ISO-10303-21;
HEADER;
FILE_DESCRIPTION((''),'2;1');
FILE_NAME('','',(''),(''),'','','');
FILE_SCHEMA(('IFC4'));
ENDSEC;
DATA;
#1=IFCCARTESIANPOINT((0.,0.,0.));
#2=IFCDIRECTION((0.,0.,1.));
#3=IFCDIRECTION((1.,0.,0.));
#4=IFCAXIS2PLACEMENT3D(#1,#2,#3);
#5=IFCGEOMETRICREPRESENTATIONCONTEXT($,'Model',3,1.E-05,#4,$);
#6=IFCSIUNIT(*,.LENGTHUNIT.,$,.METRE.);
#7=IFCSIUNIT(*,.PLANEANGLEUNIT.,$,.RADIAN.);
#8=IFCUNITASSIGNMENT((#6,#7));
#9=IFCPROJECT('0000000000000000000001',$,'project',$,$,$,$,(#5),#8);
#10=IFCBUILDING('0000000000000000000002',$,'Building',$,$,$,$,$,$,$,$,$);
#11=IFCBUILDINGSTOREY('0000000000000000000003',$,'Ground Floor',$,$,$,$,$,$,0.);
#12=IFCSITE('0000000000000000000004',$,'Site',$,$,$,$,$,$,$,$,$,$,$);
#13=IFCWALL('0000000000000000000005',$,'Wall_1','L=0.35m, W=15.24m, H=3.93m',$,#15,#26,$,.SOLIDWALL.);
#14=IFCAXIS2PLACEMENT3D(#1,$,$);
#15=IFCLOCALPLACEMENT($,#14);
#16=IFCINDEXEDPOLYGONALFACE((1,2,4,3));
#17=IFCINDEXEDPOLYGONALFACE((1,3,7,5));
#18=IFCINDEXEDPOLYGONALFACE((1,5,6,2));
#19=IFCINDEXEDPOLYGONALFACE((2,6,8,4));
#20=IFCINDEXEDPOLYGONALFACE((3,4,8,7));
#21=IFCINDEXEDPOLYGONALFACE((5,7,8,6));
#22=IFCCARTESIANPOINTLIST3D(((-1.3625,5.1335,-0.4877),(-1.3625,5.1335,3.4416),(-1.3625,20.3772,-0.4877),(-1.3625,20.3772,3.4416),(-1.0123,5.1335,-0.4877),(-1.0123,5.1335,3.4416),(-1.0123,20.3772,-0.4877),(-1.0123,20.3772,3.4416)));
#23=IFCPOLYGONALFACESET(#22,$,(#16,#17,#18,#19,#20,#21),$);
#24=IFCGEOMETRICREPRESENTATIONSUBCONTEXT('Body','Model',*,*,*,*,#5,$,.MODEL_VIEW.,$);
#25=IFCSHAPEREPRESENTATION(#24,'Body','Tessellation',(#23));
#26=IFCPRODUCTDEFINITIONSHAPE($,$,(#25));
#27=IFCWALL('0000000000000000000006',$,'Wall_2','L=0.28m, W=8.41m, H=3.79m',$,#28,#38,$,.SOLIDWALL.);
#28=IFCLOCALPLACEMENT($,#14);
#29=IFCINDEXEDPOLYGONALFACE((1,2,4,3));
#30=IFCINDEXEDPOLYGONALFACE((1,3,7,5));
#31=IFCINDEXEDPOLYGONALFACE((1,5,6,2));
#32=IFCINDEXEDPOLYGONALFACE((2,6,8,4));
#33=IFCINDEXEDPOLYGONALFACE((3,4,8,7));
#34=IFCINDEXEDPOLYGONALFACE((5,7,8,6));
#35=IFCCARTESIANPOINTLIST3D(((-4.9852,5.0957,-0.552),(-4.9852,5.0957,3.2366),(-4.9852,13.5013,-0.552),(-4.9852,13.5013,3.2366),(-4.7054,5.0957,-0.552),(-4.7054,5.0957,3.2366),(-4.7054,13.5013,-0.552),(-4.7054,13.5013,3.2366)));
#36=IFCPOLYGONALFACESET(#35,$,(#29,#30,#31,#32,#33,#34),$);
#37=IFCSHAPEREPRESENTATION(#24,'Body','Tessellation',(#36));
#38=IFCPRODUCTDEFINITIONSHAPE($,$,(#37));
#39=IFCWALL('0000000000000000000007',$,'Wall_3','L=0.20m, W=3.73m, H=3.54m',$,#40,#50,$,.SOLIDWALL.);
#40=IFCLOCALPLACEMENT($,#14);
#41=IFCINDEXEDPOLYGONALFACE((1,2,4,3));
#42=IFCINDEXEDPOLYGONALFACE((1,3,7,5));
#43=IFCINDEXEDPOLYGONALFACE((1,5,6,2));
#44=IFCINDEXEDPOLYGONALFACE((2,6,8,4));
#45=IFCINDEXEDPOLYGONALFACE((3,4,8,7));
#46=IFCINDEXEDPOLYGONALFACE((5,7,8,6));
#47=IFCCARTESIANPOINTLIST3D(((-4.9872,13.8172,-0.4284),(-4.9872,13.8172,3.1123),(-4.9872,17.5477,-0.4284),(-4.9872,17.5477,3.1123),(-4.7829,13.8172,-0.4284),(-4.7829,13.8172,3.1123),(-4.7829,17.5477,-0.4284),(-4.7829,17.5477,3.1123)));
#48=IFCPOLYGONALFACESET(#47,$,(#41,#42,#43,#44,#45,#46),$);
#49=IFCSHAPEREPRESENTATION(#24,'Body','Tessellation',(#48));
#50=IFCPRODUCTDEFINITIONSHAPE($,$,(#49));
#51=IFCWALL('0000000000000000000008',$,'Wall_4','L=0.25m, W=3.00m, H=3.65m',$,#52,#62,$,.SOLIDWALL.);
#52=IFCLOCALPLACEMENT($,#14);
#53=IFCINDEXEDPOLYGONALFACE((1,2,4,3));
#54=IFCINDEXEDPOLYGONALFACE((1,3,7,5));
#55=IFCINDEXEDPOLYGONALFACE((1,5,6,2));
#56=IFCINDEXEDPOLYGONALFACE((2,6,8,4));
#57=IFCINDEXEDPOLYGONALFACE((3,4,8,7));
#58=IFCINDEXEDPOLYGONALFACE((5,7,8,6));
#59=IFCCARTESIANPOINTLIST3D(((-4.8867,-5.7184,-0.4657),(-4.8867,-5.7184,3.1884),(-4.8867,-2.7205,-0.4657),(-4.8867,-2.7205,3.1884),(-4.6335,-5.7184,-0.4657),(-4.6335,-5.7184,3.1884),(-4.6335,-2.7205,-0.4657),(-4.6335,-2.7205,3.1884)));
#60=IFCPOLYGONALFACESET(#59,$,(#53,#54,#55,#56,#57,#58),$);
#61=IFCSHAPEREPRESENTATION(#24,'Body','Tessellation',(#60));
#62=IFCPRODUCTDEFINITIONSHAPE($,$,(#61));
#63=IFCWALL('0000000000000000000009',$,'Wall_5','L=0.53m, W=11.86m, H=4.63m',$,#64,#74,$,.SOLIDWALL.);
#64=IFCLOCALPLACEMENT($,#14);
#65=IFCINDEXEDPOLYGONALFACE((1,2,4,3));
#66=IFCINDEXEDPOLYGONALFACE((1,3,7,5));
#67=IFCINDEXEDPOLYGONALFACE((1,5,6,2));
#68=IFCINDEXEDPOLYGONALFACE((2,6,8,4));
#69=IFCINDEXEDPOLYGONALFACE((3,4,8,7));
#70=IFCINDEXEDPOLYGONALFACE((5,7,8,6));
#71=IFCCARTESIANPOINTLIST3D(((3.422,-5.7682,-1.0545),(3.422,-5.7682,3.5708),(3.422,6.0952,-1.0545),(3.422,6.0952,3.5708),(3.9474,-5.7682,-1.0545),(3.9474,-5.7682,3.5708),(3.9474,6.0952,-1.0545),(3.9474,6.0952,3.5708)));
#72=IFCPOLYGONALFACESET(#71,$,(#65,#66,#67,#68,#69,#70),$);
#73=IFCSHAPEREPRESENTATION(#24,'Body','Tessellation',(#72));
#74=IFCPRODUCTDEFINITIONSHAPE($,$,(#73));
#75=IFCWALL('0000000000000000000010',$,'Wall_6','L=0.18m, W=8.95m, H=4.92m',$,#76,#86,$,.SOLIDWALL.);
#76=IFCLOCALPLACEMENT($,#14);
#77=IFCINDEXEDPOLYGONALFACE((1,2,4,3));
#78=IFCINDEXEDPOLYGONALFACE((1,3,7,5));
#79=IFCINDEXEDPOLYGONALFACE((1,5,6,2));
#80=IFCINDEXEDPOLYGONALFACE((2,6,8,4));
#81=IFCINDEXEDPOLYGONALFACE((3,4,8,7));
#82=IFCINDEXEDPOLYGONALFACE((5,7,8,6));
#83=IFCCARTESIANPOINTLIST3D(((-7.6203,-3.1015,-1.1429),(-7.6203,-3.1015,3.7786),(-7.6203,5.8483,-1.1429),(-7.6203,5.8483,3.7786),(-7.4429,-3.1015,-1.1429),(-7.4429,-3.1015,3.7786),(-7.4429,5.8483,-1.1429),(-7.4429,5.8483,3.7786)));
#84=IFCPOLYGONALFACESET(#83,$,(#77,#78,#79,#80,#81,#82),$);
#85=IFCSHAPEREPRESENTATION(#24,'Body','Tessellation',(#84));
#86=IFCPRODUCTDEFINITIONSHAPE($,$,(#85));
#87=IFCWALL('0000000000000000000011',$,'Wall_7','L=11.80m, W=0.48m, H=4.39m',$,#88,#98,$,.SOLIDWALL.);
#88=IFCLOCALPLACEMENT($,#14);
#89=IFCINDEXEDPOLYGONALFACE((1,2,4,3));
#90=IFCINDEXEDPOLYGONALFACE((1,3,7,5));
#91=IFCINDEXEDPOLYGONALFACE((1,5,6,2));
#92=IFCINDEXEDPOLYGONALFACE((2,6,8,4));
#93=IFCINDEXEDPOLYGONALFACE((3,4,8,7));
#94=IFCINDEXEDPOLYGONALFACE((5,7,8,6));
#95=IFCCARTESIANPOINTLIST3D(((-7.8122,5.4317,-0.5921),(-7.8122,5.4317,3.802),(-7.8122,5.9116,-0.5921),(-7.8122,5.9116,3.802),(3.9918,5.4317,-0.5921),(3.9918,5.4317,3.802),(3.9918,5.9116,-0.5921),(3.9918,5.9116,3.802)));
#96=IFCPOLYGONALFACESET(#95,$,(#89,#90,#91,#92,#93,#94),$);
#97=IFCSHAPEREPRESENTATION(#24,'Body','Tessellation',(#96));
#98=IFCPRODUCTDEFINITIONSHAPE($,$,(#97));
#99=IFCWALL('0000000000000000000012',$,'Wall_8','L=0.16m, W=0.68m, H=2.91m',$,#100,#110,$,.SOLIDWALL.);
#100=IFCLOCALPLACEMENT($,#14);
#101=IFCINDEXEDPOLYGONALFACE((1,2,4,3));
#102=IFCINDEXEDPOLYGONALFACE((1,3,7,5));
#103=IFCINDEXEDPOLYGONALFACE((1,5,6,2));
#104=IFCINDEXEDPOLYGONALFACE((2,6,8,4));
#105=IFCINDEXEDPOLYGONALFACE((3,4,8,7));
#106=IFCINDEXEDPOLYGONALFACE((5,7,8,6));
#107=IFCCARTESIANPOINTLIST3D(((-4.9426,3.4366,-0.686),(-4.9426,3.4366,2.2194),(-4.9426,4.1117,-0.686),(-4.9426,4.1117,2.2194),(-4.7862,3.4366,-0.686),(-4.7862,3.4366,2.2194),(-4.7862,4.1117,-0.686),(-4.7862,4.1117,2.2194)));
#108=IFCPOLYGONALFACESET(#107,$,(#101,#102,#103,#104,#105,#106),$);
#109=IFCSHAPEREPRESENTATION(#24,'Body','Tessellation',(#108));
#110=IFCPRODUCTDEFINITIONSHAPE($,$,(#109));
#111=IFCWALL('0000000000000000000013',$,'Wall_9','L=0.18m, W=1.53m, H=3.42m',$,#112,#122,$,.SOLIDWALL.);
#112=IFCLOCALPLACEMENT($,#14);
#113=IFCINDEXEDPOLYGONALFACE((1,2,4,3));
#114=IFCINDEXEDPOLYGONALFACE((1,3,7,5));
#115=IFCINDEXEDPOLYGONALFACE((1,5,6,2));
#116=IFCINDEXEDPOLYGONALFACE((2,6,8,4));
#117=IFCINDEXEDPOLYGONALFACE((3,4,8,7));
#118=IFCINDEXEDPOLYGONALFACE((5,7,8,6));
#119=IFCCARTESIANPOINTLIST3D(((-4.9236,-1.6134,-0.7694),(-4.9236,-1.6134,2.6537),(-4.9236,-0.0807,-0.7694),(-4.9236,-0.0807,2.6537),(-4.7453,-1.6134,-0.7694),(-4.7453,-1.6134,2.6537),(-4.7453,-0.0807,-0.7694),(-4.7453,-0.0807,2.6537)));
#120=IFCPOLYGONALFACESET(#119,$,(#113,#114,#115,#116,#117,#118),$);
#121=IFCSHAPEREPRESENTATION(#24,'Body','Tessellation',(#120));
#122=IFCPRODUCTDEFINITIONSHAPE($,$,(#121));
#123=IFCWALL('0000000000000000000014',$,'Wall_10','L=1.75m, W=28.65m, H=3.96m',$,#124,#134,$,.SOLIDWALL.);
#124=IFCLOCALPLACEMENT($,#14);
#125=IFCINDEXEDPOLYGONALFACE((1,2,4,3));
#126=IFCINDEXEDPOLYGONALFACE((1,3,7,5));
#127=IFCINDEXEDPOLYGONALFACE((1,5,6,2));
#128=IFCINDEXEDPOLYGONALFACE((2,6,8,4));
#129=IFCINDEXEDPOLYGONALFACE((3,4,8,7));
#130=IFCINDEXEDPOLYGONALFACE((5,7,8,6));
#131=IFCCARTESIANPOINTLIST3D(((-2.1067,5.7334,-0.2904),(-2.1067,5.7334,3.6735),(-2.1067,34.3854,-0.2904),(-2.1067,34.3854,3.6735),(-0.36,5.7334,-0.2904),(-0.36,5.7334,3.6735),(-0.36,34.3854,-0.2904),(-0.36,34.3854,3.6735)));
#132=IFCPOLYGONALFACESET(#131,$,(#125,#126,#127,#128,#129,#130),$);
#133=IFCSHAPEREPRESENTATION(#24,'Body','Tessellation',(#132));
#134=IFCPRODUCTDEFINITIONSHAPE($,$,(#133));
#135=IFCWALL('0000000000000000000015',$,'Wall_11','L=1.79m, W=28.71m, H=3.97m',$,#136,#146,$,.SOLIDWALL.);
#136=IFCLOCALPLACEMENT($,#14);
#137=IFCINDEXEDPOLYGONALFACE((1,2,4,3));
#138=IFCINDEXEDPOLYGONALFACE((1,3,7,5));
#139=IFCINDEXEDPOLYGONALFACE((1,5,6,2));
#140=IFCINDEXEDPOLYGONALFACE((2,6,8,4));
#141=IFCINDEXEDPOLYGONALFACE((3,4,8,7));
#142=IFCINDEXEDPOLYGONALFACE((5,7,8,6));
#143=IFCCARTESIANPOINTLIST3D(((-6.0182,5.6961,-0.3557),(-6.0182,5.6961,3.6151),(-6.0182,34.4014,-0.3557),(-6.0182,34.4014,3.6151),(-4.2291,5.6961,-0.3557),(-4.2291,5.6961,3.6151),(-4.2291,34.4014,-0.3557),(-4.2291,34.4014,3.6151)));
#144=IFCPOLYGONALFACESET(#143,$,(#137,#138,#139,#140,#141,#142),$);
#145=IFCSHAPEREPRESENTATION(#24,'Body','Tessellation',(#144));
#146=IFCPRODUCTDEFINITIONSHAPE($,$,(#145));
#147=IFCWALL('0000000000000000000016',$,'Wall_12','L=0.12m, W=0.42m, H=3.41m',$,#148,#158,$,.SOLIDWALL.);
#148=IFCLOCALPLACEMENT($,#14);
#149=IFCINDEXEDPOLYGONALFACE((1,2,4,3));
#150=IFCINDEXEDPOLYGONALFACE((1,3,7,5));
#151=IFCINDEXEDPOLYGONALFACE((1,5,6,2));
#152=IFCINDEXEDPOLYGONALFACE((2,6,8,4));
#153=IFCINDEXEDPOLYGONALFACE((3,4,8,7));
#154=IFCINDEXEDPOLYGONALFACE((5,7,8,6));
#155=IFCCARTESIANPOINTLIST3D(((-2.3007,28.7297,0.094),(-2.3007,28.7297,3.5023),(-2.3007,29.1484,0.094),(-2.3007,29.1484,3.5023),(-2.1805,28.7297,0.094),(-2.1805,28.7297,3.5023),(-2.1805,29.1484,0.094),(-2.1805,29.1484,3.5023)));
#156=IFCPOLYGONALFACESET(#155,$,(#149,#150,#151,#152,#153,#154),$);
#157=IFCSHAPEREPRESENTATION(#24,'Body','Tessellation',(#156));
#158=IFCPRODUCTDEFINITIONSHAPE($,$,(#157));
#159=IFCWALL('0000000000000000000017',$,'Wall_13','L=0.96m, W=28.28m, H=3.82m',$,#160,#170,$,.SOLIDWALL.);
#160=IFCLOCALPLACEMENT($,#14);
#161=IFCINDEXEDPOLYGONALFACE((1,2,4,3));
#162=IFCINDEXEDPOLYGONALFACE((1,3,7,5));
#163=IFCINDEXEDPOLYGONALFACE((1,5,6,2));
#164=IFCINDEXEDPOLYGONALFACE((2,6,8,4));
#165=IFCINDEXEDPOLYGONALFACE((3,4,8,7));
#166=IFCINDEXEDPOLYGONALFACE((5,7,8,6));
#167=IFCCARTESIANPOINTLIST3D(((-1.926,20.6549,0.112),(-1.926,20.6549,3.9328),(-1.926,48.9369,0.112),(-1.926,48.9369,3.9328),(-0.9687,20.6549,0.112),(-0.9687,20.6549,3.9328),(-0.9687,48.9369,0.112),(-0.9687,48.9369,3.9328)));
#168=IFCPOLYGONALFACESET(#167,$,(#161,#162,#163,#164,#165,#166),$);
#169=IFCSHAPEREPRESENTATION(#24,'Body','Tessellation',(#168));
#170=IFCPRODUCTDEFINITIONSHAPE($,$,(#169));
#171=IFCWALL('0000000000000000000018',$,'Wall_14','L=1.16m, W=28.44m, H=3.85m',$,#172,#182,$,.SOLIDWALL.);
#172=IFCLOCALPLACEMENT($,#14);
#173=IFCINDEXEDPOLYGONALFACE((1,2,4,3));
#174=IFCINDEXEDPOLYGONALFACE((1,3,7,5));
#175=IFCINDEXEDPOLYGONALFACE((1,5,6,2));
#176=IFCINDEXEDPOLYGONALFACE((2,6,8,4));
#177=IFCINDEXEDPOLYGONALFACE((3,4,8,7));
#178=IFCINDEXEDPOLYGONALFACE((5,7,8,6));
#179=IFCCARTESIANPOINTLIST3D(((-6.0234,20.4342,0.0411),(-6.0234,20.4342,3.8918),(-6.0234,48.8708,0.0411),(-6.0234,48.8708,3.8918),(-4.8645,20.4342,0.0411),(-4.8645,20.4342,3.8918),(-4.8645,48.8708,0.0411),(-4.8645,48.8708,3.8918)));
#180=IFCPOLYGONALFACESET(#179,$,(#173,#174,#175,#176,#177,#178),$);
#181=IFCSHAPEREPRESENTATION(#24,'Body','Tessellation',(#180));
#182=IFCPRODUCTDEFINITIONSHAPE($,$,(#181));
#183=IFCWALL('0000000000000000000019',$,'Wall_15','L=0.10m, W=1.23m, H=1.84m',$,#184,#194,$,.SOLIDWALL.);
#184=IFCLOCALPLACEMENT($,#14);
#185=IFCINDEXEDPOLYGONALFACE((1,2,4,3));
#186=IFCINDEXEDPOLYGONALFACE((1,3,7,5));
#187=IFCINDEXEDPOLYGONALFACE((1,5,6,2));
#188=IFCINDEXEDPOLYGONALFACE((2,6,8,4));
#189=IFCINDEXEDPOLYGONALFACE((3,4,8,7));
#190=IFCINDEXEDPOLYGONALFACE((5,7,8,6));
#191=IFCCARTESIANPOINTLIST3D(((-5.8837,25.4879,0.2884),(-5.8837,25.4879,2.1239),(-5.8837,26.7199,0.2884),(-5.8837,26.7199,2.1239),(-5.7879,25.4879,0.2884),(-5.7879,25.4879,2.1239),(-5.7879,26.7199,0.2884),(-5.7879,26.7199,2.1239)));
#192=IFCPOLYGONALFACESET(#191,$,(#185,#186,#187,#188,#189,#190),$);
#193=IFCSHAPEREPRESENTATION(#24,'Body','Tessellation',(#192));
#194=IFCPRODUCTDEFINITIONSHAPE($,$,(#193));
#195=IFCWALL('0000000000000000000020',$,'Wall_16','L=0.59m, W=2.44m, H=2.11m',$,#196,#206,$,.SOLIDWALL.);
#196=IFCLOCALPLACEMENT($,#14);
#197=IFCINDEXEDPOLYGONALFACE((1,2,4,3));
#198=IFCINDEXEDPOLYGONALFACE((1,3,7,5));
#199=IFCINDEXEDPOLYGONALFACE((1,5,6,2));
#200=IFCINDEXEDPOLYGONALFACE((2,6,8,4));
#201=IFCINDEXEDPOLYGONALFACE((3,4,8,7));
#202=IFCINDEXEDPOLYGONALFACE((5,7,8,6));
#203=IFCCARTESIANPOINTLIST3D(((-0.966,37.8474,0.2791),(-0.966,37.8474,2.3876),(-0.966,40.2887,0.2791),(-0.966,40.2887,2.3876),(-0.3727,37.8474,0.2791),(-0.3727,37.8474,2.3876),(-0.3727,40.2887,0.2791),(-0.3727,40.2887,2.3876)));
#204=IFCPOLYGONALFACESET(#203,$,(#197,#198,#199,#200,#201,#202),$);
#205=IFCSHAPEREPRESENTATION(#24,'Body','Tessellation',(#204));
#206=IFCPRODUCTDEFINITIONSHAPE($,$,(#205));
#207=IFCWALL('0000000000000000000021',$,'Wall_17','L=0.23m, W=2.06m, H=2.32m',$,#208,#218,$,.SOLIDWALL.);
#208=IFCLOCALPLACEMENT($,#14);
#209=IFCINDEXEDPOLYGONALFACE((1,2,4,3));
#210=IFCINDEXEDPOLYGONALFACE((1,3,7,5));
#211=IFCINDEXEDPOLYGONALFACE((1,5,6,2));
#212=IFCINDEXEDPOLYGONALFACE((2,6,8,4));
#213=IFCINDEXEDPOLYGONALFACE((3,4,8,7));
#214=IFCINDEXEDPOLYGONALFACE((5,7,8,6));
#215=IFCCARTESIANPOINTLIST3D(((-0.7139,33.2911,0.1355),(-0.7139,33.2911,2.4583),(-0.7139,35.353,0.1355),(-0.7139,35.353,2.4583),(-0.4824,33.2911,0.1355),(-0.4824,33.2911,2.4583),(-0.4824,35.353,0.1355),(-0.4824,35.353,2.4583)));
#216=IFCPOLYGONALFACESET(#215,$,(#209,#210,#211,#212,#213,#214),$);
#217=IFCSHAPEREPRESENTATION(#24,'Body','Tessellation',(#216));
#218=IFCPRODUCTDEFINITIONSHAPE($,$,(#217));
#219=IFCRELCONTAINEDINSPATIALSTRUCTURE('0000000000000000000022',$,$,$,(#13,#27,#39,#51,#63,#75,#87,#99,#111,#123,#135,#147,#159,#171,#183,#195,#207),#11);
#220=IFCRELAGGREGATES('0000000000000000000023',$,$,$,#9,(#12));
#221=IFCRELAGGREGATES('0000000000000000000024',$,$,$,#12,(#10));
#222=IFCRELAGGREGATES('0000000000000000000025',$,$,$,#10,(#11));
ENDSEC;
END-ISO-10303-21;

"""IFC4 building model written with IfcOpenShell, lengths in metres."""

from ifc_helpers import new_model, si_unit, frame, origin_with_axes, origin_2d, context, subcontext, project, spatial, rectangle, extrude, element, save


model = new_model("IFC4")

# Units and contexts
model_context = context("Model", 3, precision=1e-05, world=origin_with_axes())
body_context = subcontext(model_context, "Body", "Model", "MODEL_VIEW")
ifc_project = project(units=[si_unit("LENGTHUNIT", "METRE"), si_unit("PLANEANGLEUNIT", "RADIAN")], contexts=[model_context])

# Site, building, storey
site = spatial("IfcSite", under=ifc_project, Name="Site")
building = spatial("IfcBuilding", under=site, Name="Building")
storey = spatial("IfcBuildingStorey", under=building, Name="Ground Floor", Elevation=0.0)

# Walls
element("IfcWall", 1, inside=storey, Name="Wall_1", Description="L=0.35m, W=15.24m, H=3.93m", PredefinedType="SOLIDWALL", context=body_context, shape_type="SweptSolid", body=[
    extrude(rectangle(XDim=0.3502, YDim=15.2437, at=origin_2d()), frame((-1.1874, 12.7554, -0.4877), z_axis=(0.0, 0.0, 1.0), x_axis=(1.0, 0.0, 0.0)), (0.0, 0.0, 1.0), 3.9293),
])
element("IfcWall", 2, inside=storey, Name="Wall_2", Description="L=0.28m, W=8.41m, H=3.79m", PredefinedType="SOLIDWALL", context=body_context, shape_type="SweptSolid", body=[
    extrude(rectangle(XDim=0.2798, YDim=8.4056, at=origin_2d()), frame((-4.8453, 9.2985, -0.552), z_axis=(0.0, 0.0, 1.0), x_axis=(1.0, 0.0, 0.0)), (0.0, 0.0, 1.0), 3.7887),
])
element("IfcWall", 3, inside=storey, Name="Wall_3", Description="L=0.20m, W=3.73m, H=3.54m", PredefinedType="SOLIDWALL", context=body_context, shape_type="SweptSolid", body=[
    extrude(rectangle(XDim=0.2044, YDim=3.7305, at=origin_2d()), frame((-4.885, 15.6825, -0.4284), z_axis=(0.0, 0.0, 1.0), x_axis=(1.0, 0.0, 0.0)), (0.0, 0.0, 1.0), 3.5408),
])
element("IfcWall", 4, inside=storey, Name="Wall_4", Description="L=0.25m, W=3.00m, H=3.65m", PredefinedType="SOLIDWALL", context=body_context, shape_type="SweptSolid", body=[
    extrude(rectangle(XDim=0.2532, YDim=2.9979, at=origin_2d()), frame((-4.7601, -4.2195, -0.4657), z_axis=(0.0, 0.0, 1.0), x_axis=(1.0, 0.0, 0.0)), (0.0, 0.0, 1.0), 3.6541),
])
element("IfcWall", 5, inside=storey, Name="Wall_5", Description="L=0.53m, W=11.86m, H=4.63m", PredefinedType="SOLIDWALL", context=body_context, shape_type="SweptSolid", body=[
    extrude(rectangle(XDim=0.5253, YDim=11.8635, at=origin_2d()), frame((3.6847, 0.1635, -1.0545), z_axis=(0.0, 0.0, 1.0), x_axis=(1.0, 0.0, 0.0)), (0.0, 0.0, 1.0), 4.6253),
])
element("IfcWall", 6, inside=storey, Name="Wall_6", Description="L=0.18m, W=8.95m, H=4.92m", PredefinedType="SOLIDWALL", context=body_context, shape_type="SweptSolid", body=[
    extrude(rectangle(XDim=0.1774, YDim=8.9498, at=origin_2d()), frame((-7.5316, 1.3734, -1.1429), z_axis=(0.0, 0.0, 1.0), x_axis=(1.0, 0.0, 0.0)), (0.0, 0.0, 1.0), 4.9215),
])
element("IfcWall", 7, inside=storey, Name="Wall_7", Description="L=11.80m, W=0.48m, H=4.39m", PredefinedType="SOLIDWALL", context=body_context, shape_type="SweptSolid", body=[
    extrude(rectangle(XDim=11.804, YDim=0.4799, at=origin_2d()), frame((-1.9102, 5.6717, -0.5921), z_axis=(0.0, 0.0, 1.0), x_axis=(1.0, 0.0, 0.0)), (0.0, 0.0, 1.0), 4.3941),
])
element("IfcWall", 8, inside=storey, Name="Wall_8", Description="L=0.16m, W=0.68m, H=2.91m", PredefinedType="SOLIDWALL", context=body_context, shape_type="SweptSolid", body=[
    extrude(rectangle(XDim=0.1564, YDim=0.6751, at=origin_2d()), frame((-4.8644, 3.7741, -0.686), z_axis=(0.0, 0.0, 1.0), x_axis=(1.0, 0.0, 0.0)), (0.0, 0.0, 1.0), 2.9054),
])
element("IfcWall", 9, inside=storey, Name="Wall_9", Description="L=0.18m, W=1.53m, H=3.42m", PredefinedType="SOLIDWALL", context=body_context, shape_type="SweptSolid", body=[
    extrude(rectangle(XDim=0.1784, YDim=1.5328, at=origin_2d()), frame((-4.8344, -0.8471, -0.7694), z_axis=(0.0, 0.0, 1.0), x_axis=(1.0, 0.0, 0.0)), (0.0, 0.0, 1.0), 3.4231),
])
element("IfcWall", 10, inside=storey, Name="Wall_10", Description="L=1.75m, W=28.65m, H=3.96m", PredefinedType="SOLIDWALL", context=body_context, shape_type="SweptSolid", body=[
    extrude(rectangle(XDim=1.7468, YDim=28.652, at=origin_2d()), frame((-1.2334, 20.0594, -0.2904), z_axis=(0.0, 0.0, 1.0), x_axis=(1.0, 0.0, 0.0)), (0.0, 0.0, 1.0), 3.9639),
])
element("IfcWall", 11, inside=storey, Name="Wall_11", Description="L=1.79m, W=28.71m, H=3.97m", PredefinedType="SOLIDWALL", context=body_context, shape_type="SweptSolid", body=[
    extrude(rectangle(XDim=1.7891, YDim=28.7054, at=origin_2d()), frame((-5.1237, 20.0488, -0.3557), z_axis=(0.0, 0.0, 1.0), x_axis=(1.0, 0.0, 0.0)), (0.0, 0.0, 1.0), 3.9707),
])
element("IfcWall", 12, inside=storey, Name="Wall_12", Description="L=0.12m, W=0.42m, H=3.41m", PredefinedType="SOLIDWALL", context=body_context, shape_type="SweptSolid", body=[
    extrude(rectangle(XDim=0.1202, YDim=0.4187, at=origin_2d()), frame((-2.2406, 28.939, 0.094), z_axis=(0.0, 0.0, 1.0), x_axis=(1.0, 0.0, 0.0)), (0.0, 0.0, 1.0), 3.4083),
])
element("IfcWall", 13, inside=storey, Name="Wall_13", Description="L=0.96m, W=28.28m, H=3.82m", PredefinedType="SOLIDWALL", context=body_context, shape_type="SweptSolid", body=[
    extrude(rectangle(XDim=0.9572, YDim=28.282, at=origin_2d()), frame((-1.4474, 34.7959, 0.112), z_axis=(0.0, 0.0, 1.0), x_axis=(1.0, 0.0, 0.0)), (0.0, 0.0, 1.0), 3.8208),
])
element("IfcWall", 14, inside=storey, Name="Wall_14", Description="L=1.16m, W=28.44m, H=3.85m", PredefinedType="SOLIDWALL", context=body_context, shape_type="SweptSolid", body=[
    extrude(rectangle(XDim=1.1588, YDim=28.4366, at=origin_2d()), frame((-5.444, 34.6525, 0.0411), z_axis=(0.0, 0.0, 1.0), x_axis=(1.0, 0.0, 0.0)), (0.0, 0.0, 1.0), 3.8507),
])
element("IfcWall", 15, inside=storey, Name="Wall_15", Description="L=0.10m, W=1.23m, H=1.84m", PredefinedType="SOLIDWALL", context=body_context, shape_type="SweptSolid", body=[
    extrude(rectangle(XDim=0.0958, YDim=1.232, at=origin_2d()), frame((-5.8358, 26.1039, 0.2884), z_axis=(0.0, 0.0, 1.0), x_axis=(1.0, 0.0, 0.0)), (0.0, 0.0, 1.0), 1.8355),
])
element("IfcWall", 16, inside=storey, Name="Wall_16", Description="L=0.59m, W=2.44m, H=2.11m", PredefinedType="SOLIDWALL", context=body_context, shape_type="SweptSolid", body=[
    extrude(rectangle(XDim=0.5933, YDim=2.4412, at=origin_2d()), frame((-0.6693, 39.0681, 0.2791), z_axis=(0.0, 0.0, 1.0), x_axis=(1.0, 0.0, 0.0)), (0.0, 0.0, 1.0), 2.1085),
])
element("IfcWall", 17, inside=storey, Name="Wall_17", Description="L=0.23m, W=2.06m, H=2.32m", PredefinedType="SOLIDWALL", context=body_context, shape_type="SweptSolid", body=[
    extrude(rectangle(XDim=0.2315, YDim=2.0619, at=origin_2d()), frame((-0.5982, 34.3221, 0.1355), z_axis=(0.0, 0.0, 1.0), x_axis=(1.0, 0.0, 0.0)), (0.0, 0.0, 1.0), 2.3228),
])

save(model, "model.ifc")
